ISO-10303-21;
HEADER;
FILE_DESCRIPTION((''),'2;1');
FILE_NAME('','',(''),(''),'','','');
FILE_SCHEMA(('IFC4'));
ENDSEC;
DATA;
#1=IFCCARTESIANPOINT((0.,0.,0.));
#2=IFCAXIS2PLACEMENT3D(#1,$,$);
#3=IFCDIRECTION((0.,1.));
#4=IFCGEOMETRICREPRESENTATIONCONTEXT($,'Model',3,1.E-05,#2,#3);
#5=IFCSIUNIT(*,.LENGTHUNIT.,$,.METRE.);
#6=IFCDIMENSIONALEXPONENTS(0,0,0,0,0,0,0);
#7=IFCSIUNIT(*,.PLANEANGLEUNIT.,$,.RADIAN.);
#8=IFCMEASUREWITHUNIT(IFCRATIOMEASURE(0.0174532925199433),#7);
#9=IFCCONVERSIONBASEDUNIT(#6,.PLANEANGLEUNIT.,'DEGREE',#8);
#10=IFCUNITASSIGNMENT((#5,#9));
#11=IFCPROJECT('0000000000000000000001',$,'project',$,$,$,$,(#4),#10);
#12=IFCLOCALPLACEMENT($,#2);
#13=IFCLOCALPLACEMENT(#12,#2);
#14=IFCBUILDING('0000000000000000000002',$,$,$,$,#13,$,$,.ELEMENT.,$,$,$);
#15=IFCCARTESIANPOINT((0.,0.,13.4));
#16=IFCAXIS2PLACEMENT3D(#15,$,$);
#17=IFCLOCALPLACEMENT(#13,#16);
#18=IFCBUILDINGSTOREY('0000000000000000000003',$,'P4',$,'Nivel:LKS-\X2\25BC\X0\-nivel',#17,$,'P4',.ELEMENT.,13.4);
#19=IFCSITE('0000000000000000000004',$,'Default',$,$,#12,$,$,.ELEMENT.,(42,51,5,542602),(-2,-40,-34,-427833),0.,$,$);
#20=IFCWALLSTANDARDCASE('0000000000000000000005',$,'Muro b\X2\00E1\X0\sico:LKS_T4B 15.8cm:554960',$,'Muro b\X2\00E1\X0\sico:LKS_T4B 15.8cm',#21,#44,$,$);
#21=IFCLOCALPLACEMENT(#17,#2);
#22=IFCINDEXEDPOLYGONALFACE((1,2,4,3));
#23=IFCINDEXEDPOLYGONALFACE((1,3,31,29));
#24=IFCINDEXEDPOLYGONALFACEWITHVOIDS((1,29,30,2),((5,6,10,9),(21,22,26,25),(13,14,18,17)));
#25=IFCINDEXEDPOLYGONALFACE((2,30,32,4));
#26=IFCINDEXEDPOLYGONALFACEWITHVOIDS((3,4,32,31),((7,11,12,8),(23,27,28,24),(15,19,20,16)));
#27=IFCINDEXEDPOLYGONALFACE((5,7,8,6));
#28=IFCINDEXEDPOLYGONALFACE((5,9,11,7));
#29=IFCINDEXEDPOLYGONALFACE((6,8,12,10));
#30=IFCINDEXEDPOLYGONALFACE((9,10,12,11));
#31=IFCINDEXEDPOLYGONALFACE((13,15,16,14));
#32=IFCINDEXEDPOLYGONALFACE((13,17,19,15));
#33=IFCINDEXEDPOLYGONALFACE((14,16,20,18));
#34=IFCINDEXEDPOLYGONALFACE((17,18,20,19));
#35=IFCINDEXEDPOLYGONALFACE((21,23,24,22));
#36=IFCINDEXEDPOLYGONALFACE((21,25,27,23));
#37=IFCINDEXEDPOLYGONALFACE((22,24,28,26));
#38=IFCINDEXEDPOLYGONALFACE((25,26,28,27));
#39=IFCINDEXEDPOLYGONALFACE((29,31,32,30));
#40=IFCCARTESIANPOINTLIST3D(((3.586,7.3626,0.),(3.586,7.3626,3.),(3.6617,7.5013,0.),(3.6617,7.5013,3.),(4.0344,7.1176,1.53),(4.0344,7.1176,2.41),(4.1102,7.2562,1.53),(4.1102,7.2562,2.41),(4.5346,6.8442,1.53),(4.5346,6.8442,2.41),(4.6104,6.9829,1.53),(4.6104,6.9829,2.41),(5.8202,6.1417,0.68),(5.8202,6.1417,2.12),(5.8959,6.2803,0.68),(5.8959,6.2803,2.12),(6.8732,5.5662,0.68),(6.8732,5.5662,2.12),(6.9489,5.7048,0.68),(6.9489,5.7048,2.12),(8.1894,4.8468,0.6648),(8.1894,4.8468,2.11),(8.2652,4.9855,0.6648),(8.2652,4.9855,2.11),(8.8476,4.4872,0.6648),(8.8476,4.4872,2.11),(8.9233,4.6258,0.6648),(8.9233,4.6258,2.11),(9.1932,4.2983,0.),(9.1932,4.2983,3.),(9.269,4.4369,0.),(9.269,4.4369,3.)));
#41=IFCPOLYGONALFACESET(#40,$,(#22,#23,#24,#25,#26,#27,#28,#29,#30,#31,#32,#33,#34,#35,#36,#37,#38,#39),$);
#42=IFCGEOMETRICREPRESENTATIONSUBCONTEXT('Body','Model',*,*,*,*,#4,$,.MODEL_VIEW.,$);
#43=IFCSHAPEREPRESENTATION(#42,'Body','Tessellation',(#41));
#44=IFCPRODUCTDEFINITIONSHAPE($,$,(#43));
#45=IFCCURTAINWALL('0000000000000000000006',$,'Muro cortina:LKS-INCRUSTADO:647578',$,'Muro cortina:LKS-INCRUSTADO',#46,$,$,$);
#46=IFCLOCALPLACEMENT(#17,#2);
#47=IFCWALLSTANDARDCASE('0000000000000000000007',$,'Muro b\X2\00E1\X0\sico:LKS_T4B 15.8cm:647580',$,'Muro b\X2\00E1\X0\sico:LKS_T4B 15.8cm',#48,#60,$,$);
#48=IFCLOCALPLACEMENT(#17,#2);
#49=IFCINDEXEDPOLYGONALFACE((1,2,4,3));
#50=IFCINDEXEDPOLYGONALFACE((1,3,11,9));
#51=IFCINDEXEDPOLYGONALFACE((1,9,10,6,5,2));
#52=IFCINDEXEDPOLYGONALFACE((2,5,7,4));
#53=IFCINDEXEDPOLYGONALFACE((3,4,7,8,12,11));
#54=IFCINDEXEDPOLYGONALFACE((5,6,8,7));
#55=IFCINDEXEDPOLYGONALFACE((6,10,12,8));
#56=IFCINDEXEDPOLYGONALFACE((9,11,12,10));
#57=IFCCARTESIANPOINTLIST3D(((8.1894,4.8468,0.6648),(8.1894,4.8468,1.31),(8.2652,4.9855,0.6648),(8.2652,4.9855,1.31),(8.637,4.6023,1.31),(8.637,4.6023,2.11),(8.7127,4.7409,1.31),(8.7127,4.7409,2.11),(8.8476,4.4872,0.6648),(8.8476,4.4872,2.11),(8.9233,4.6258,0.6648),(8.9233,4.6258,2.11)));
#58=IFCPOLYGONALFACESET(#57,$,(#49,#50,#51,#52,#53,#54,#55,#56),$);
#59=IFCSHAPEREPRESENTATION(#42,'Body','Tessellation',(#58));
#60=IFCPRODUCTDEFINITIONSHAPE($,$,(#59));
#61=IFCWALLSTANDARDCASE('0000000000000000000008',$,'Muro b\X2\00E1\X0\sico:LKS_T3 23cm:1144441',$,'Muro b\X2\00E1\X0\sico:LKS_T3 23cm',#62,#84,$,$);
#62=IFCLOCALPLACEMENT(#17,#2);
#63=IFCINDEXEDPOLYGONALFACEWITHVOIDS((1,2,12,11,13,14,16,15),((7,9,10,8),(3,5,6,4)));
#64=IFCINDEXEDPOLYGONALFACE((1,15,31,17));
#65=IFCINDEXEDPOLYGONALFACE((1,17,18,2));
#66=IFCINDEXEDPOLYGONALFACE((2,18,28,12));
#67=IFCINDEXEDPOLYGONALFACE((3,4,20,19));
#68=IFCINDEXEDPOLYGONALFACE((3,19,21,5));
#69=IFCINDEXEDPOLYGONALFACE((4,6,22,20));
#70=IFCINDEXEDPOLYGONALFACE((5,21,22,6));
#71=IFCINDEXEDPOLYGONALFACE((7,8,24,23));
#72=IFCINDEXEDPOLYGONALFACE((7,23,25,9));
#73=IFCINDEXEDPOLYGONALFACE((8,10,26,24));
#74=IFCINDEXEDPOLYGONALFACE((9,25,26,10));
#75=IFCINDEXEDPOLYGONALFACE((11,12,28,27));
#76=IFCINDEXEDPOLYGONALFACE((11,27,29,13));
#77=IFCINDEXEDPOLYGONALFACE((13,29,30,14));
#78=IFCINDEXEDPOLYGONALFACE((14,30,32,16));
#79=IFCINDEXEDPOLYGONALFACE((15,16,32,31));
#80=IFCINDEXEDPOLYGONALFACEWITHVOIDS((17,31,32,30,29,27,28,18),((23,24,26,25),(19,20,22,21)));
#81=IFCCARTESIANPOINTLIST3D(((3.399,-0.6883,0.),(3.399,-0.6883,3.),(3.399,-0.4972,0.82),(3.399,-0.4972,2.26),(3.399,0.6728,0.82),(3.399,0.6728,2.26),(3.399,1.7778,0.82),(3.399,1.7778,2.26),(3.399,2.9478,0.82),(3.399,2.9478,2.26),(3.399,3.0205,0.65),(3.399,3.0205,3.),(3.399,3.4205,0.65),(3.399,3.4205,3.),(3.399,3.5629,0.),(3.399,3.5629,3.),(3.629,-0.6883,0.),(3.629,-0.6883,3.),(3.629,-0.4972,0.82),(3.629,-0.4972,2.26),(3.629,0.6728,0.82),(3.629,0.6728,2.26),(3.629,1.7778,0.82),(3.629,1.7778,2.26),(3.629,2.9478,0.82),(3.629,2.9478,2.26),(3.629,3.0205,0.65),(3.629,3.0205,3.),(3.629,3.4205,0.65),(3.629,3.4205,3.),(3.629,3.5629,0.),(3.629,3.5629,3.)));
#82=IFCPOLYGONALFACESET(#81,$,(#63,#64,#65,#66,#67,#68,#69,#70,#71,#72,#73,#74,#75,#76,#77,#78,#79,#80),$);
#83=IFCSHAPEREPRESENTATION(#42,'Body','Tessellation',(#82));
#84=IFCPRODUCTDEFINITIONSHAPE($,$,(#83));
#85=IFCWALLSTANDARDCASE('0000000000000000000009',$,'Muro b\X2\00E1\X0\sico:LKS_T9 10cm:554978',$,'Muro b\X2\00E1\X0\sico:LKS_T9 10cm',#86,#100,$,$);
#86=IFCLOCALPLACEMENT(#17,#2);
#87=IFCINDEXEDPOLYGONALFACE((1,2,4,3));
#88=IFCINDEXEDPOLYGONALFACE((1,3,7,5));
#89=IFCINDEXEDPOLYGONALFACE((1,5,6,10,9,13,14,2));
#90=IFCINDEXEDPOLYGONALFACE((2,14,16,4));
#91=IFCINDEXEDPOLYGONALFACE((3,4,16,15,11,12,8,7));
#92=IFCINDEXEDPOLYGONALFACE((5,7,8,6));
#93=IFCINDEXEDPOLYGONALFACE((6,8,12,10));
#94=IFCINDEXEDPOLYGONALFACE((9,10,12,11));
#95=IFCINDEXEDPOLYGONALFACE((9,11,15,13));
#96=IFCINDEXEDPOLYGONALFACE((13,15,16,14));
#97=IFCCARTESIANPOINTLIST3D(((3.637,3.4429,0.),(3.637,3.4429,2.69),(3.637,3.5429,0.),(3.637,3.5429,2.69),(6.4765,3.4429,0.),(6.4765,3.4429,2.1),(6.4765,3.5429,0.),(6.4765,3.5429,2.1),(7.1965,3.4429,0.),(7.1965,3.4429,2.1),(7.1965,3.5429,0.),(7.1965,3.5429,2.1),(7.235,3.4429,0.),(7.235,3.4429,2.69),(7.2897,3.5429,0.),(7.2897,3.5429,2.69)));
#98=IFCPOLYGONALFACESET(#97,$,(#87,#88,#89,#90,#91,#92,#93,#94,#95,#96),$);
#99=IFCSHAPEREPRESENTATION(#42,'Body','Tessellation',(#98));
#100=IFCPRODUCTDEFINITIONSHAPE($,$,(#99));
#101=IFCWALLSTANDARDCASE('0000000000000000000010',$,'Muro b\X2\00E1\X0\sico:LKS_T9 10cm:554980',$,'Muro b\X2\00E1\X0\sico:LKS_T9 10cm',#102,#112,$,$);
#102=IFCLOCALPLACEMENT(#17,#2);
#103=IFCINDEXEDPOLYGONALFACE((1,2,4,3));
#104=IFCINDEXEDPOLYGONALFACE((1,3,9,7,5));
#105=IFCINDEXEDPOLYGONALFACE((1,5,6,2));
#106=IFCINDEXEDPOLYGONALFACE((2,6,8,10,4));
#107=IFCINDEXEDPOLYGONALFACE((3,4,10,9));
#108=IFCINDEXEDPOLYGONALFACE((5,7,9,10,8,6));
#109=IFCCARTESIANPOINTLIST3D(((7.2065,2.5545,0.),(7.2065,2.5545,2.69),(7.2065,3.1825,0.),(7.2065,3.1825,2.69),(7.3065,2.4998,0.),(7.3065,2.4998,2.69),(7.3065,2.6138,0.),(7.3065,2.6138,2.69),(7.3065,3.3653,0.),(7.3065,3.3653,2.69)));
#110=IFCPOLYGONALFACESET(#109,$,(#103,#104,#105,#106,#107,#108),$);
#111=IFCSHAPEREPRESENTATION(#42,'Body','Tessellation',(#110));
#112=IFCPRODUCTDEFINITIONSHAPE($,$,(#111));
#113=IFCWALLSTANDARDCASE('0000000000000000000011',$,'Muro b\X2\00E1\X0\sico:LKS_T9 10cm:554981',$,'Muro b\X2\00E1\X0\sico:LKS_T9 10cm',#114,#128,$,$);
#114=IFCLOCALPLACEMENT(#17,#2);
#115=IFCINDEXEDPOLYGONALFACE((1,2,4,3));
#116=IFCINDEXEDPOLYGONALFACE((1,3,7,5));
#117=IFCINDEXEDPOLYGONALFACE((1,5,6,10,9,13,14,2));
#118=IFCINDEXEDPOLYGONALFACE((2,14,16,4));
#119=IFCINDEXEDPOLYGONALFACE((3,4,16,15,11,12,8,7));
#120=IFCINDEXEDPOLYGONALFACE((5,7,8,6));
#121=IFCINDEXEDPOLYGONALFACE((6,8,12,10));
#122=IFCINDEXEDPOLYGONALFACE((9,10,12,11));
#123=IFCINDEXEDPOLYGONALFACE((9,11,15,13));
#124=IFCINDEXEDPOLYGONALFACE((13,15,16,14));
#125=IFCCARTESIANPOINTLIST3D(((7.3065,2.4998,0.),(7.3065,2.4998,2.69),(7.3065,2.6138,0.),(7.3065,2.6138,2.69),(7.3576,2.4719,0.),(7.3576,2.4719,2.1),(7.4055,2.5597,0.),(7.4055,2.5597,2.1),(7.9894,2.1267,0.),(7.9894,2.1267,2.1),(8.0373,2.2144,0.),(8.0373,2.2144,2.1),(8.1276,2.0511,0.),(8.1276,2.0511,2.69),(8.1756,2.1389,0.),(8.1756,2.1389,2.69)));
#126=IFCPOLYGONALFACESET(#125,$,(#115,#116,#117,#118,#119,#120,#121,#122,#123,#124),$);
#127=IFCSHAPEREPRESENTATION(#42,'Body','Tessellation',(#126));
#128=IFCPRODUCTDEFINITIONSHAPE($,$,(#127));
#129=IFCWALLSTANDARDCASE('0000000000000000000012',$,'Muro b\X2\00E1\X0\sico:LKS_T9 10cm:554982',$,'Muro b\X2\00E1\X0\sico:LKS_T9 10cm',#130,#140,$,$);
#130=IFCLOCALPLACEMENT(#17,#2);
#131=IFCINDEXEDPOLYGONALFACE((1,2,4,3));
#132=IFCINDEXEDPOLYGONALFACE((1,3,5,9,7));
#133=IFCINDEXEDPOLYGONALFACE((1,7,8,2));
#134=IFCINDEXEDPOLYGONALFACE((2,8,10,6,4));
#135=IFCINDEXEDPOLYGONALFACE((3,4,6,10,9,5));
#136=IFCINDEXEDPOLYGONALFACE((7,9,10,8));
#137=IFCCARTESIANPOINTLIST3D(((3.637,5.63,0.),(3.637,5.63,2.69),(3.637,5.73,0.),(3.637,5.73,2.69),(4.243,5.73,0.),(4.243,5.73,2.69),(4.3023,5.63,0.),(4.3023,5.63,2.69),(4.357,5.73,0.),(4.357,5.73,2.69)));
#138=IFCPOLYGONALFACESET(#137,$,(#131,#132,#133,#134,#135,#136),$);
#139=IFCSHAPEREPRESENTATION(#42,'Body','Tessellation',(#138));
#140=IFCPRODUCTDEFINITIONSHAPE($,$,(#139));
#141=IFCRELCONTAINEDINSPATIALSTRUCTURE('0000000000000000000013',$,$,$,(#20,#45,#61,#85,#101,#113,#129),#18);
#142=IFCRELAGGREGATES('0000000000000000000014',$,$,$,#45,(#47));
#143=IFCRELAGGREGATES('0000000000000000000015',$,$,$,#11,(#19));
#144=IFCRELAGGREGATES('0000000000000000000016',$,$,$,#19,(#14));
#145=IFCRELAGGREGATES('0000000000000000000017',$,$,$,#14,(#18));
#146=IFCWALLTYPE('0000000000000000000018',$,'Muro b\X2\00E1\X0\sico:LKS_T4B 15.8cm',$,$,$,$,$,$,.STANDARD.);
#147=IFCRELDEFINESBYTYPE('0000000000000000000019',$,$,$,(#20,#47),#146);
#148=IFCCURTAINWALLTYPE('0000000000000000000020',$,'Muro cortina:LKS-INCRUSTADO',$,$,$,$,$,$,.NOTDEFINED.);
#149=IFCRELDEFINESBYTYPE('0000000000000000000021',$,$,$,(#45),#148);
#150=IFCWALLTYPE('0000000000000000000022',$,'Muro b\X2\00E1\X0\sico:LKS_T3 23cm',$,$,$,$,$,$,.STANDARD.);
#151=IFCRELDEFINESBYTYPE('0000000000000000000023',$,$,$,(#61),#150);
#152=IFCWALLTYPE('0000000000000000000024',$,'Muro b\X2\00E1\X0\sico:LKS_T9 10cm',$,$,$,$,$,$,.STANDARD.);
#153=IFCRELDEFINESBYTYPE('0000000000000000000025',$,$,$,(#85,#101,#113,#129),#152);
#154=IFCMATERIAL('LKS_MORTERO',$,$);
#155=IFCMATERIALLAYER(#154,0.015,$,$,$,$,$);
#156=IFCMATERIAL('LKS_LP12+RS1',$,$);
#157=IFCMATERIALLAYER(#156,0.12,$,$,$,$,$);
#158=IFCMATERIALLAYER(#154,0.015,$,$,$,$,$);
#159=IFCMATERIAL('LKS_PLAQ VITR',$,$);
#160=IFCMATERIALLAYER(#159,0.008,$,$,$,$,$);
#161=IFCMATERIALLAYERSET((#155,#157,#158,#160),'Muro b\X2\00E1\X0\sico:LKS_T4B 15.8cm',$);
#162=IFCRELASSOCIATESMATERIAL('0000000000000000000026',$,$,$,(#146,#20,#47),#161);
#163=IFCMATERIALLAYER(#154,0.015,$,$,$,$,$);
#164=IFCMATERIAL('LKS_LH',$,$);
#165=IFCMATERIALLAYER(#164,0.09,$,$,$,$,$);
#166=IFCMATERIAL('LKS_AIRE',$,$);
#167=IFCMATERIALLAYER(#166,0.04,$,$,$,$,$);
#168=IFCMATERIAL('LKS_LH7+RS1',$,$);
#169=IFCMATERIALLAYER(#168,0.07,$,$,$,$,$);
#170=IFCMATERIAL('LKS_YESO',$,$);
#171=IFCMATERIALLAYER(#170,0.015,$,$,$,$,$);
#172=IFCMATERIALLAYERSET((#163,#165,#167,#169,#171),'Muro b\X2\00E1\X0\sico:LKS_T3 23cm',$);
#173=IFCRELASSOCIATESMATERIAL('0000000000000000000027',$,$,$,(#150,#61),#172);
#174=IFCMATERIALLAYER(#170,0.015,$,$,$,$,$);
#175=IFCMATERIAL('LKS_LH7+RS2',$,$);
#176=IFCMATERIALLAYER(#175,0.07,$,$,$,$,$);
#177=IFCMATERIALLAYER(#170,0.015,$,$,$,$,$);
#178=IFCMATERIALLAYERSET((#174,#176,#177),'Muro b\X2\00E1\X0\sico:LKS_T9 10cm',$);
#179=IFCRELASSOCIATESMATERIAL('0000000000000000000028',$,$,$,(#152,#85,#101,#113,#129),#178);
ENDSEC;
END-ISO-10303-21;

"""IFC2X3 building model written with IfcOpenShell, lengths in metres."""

from ifc_helpers import new_model, entity, si_unit, converted_unit, direction, frame, frame_2d, origin, place, context, subcontext, project, spatial, polyline, rectangle, outline, extrude, clip, bounded_halfspace, material, layer, layer_set, layer_usage, type_object, element, aggregate, save


model = new_model("IFC2X3")

# Units and contexts
model_context = context("Model", 3, precision=1e-05, world=origin(), true_north=direction((0.0, 1.0)))
body_context = subcontext(model_context, "Body", "Model", "MODEL_VIEW")
ifc_project = project(units=[si_unit("LENGTHUNIT", "METRE"), converted_unit("PLANEANGLEUNIT", "DEGREE", entity("IfcRatioMeasure", 0.0174532925199433), si_unit("PLANEANGLEUNIT", "RADIAN"), dimensions=[0, 0, 0, 0, 0, 0, 0])], contexts=[model_context])

# Site, building, storey
site_placement = place(None, origin())
site = spatial("IfcSite", under=ifc_project, at=site_placement, Name="Default", CompositionType="ELEMENT", RefLatitude=(42, 51, 5, 542602), RefLongitude=(-2, -40, -34, -427833), RefElevation=0.0)
building_placement = place(site_placement, origin())
building = spatial("IfcBuilding", under=site, at=building_placement, CompositionType="ELEMENT")
storey_placement = place(building_placement, frame((0.0, 0.0, 13.4)))
storey = spatial("IfcBuildingStorey", under=building, at=storey_placement, Name="P4", ObjectType="Nivel:LKS-▼-nivel", LongName="P4", CompositionType="ELEMENT", Elevation=13.4)

# Shared definitions
ifc_material_1 = material(Name="LKS_MORTERO")
ifc_layer_1 = layer(ifc_material_1, 0.015)
ifc_material_2 = material(Name="LKS_LP12+RS1")
ifc_layer_2 = layer(ifc_material_2, 0.12)
ifc_layer_3 = layer(ifc_material_1, 0.015)
ifc_material_3 = material(Name="LKS_PLAQ VITR")
ifc_layer_4 = layer(ifc_material_3, 0.008)
ifc_layer_set_1 = layer_set([ifc_layer_1, ifc_layer_2, ifc_layer_3, ifc_layer_4], Name="Muro básico:LKS_T4B 15.8cm")
wall_type_1 = type_object("IfcWallType", Name="Muro básico:LKS_T4B 15.8cm", PredefinedType="STANDARD", material=ifc_layer_set_1)

# Wall, openings
ifc_layer_usage_1 = layer_usage(ifc_layer_set_1, "AXIS2", "POSITIVE", -0.079)
wall_1_placement = place(storey_placement, frame((9.2311, 4.3676, 0.0), z_axis=(0.0, 0.0, 1.0), x_axis=(-0.877509, 0.479561, 0.0)))
wall_1 = element("IfcWallStandardCase", 1, at=wall_1_placement, inside=storey, type_object=wall_type_1, material=ifc_layer_usage_1, Name="Muro básico:LKS_T4B 15.8cm:554960", ObjectType="Muro básico:LKS_T4B 15.8cm", context=body_context, shape_type="Clipping", body=[
    clip(clip(extrude(rectangle(XDim=6.39, YDim=0.158, at=frame_2d((3.195, 0.0), x_axis=(-1.0, 0.0))), origin(), (0.0, 0.0, 1.0), 3.0), bounded_halfspace(frame((6.39, -0.079, 3.0), z_axis=(-1.0, 0.0, 0.0), x_axis=(0.0, 0.0, -1.0)), True, frame((6.39, -0.079, 3.0), z_axis=(-1.0, 0.0, 0.0), x_axis=(0.0, 0.0, -1.0)), polyline([(0.0, 0.0), (0.0, -0.0455), (0.0, -0.158), (3.0, -0.158), (3.0, 0.0), (0.0, 0.0)]))), bounded_halfspace(frame((0.0, -0.079, 0.0), z_axis=(1.0, 0.0, 0.0), x_axis=(0.0, 0.0, -1.0)), True, frame((0.0, -0.079, 0.0), z_axis=(1.0, 0.0, 0.0), x_axis=(0.0, 0.0, -1.0)), polyline([(0.0, 0.0), (0.0, 0.158), (-3.0, 0.158), (-3.0, 0.0488), (-3.0, 0.0), (0.0, 0.0)]))),
])
opening_1_placement = place(wall_1_placement, origin())
element("IfcOpeningElement", 2, at=opening_1_placement, cuts=wall_1, ObjectType="Opening", context=body_context, shape_type="SweptSolid", body=[
    extrude(rectangle(XDim=1.4452, YDim=0.75, at=frame_2d((0.0, 0.0), x_axis=(0.0, 1.0))), frame((0.7689, -0.2314, 1.3874), z_axis=(0.0, 1.0, 0.0), x_axis=(-1.0, 0.0, 0.0)), (0.0, 0.0, 1.0), 0.4628),
])
opening_2_placement = place(wall_1_placement, frame((3.8439, 0.079, 0.68)))
element("IfcOpeningElement", 3, at=opening_2_placement, cuts=wall_1, ObjectType="Opening", context=body_context, shape_type="SweptSolid", body=[
    extrude(rectangle(XDim=1.44, YDim=1.2, at=frame_2d((0.72, 0.6), x_axis=(1.0, 0.0))), frame((0.0, 0.0, 0.0), z_axis=(0.0, -1.0, 0.0), x_axis=(0.0, 0.0, 1.0)), (0.0, 0.0, 1.0), 0.158),
])
opening_3_placement = place(wall_1_placement, frame((5.8789, 0.079, 1.53)))
element("IfcOpeningElement", 4, at=opening_3_placement, cuts=wall_1, ObjectType="Opening", context=body_context, shape_type="SweptSolid", body=[
    extrude(rectangle(XDim=0.88, YDim=0.57, at=frame_2d((0.44, 0.285), x_axis=(1.0, 0.0))), frame((0.0, 0.0, 0.0), z_axis=(0.0, -1.0, 0.0), x_axis=(0.0, 0.0, 1.0)), (0.0, 0.0, 1.0), 0.158),
])

# Curtain wall, wall, opening
curtain_wall_type = type_object("IfcCurtainWallType", Name="Muro cortina:LKS-INCRUSTADO", PredefinedType="NOTDEFINED")
curtain_wall_placement = place(storey_placement, frame((0.0, 0.0, -13.4)))
curtain_wall = element("IfcCurtainWall", 5, at=curtain_wall_placement, inside=storey, type_object=curtain_wall_type, Name="Muro cortina:LKS-INCRUSTADO:647578", ObjectType="Muro cortina:LKS-INCRUSTADO")
ifc_layer_usage_2 = layer_usage(ifc_layer_set_1, "AXIS2", "NEGATIVE", 0.079)
wall_2_placement = place(storey_placement, frame((8.2273, 4.9162, 0.6648), z_axis=(0.0, 0.0, 1.0), x_axis=(0.877509, -0.479561, 0.0)))
wall_2 = element("IfcWallStandardCase", 6, at=wall_2_placement, type_object=wall_type_1, material=ifc_layer_usage_2, Name="Muro básico:LKS_T4B 15.8cm:647580", ObjectType="Muro básico:LKS_T4B 15.8cm", context=body_context, shape_type="SweptSolid", body=[
    extrude(rectangle(XDim=0.75, YDim=0.158, at=frame_2d((0.375, 0.0), x_axis=(-1.0, 0.0))), origin(), (0.0, 0.0, 1.0), 1.4452),
])
opening_4_placement = place(wall_2_placement, frame((0.0, -0.079, 0.6452)))
element("IfcOpeningElement", 7, at=opening_4_placement, cuts=wall_2, ObjectType="Opening", context=body_context, shape_type="SweptSolid", body=[
    extrude(rectangle(XDim=0.81, YDim=0.51, at=frame_2d((0.405, 0.255), x_axis=(1.0, 0.0))), frame((0.0, 0.0, 0.0), z_axis=(0.0, 1.0, 0.0), x_axis=(0.0, 0.0, 1.0)), (0.0, 0.0, 1.0), 0.158),
])
aggregate(curtain_wall, [wall_2])

# Wall, openings
ifc_layer_5 = layer(ifc_material_1, 0.015)
ifc_material_4 = material(Name="LKS_LH")
ifc_layer_6 = layer(ifc_material_4, 0.09)
ifc_material_5 = material(Name="LKS_AIRE")
ifc_layer_7 = layer(ifc_material_5, 0.04)
ifc_material_6 = material(Name="LKS_LH7+RS1")
ifc_layer_8 = layer(ifc_material_6, 0.07)
ifc_material_7 = material(Name="LKS_YESO")
ifc_layer_9 = layer(ifc_material_7, 0.015)
ifc_layer_set_2 = layer_set([ifc_layer_5, ifc_layer_6, ifc_layer_7, ifc_layer_8, ifc_layer_9], Name="Muro básico:LKS_T3 23cm")
ifc_layer_usage_3 = layer_usage(ifc_layer_set_2, "AXIS2", "NEGATIVE", 0.115)
wall_type_2 = type_object("IfcWallType", Name="Muro básico:LKS_T3 23cm", PredefinedType="STANDARD", material=ifc_layer_set_2)
wall_3_placement = place(storey_placement, frame((3.514, 3.5629, 0.0), z_axis=(0.0, 0.0, 1.0), x_axis=(0.0, -1.0, 0.0)))
wall_3 = element("IfcWallStandardCase", 8, at=wall_3_placement, inside=storey, type_object=wall_type_2, material=ifc_layer_usage_3, Name="Muro básico:LKS_T3 23cm:1144441", ObjectType="Muro básico:LKS_T3 23cm", context=body_context, shape_type="Clipping", body=[
    clip(extrude(rectangle(XDim=4.2511, YDim=0.23, at=frame_2d((2.1256, 0.0), x_axis=(-1.0, 0.0))), origin(), (0.0, 0.0, 1.0), 3.0), bounded_halfspace(frame((0.5424, -0.115, 0.65), z_axis=(0.0, 0.0, -1.0), x_axis=(0.0, -1.0, 0.0)), True, frame((0.5424, -0.115, 0.65), z_axis=(0.0, 0.0, -1.0), x_axis=(0.0, -1.0, 0.0)), polyline([(0.0, 0.0), (0.0, 0.4), (-0.23, 0.4), (-0.23, 0.0), (0.0, 0.0)]))),
])
opening_5_placement = place(wall_3_placement, frame((4.0601, 0.115, 0.82)))
element("IfcOpeningElement", 9, at=opening_5_placement, cuts=wall_3, ObjectType="Opening", context=body_context, shape_type="SweptSolid", body=[
    extrude(rectangle(XDim=1.44, YDim=1.17, at=frame_2d((0.72, 0.585), x_axis=(1.0, 0.0))), frame((0.0, 0.0, 0.0), z_axis=(0.0, -1.0, 0.0), x_axis=(0.0, 0.0, 1.0)), (0.0, 0.0, 1.0), 0.23),
])
opening_6_placement = place(wall_3_placement, frame((1.7851, 0.115, 0.82)))
element("IfcOpeningElement", 10, at=opening_6_placement, cuts=wall_3, ObjectType="Opening", context=body_context, shape_type="SweptSolid", body=[
    extrude(rectangle(XDim=1.44, YDim=1.17, at=frame_2d((0.72, 0.585), x_axis=(1.0, 0.0))), frame((0.0, 0.0, 0.0), z_axis=(0.0, -1.0, 0.0), x_axis=(0.0, 0.0, 1.0)), (0.0, 0.0, 1.0), 0.23),
])

# Wall, opening
ifc_layer_10 = layer(ifc_material_7, 0.015)
ifc_material_8 = material(Name="LKS_LH7+RS2")
ifc_layer_11 = layer(ifc_material_8, 0.07)
ifc_layer_12 = layer(ifc_material_7, 0.015)
ifc_layer_set_3 = layer_set([ifc_layer_10, ifc_layer_11, ifc_layer_12], Name="Muro básico:LKS_T9 10cm")
ifc_layer_usage_4 = layer_usage(ifc_layer_set_3, "AXIS2", "NEGATIVE", 0.05)
wall_type_3 = type_object("IfcWallType", Name="Muro básico:LKS_T9 10cm", PredefinedType="STANDARD", material=ifc_layer_set_3)
wall_4_placement = place(storey_placement, frame((7.2897, 3.4929, 0.0), z_axis=(0.0, 0.0, 1.0), x_axis=(-1.0, 0.0, 0.0)))
wall_4 = element("IfcWallStandardCase", 11, at=wall_4_placement, inside=storey, type_object=wall_type_3, material=ifc_layer_usage_4, Name="Muro básico:LKS_T9 10cm:554978", ObjectType="Muro básico:LKS_T9 10cm", context=body_context, shape_type="SweptSolid", body=[
    extrude(outline(polyline([(0.0, -0.05), (3.6528, -0.05), (3.6528, 0.05), (1.0132, 0.05), (0.9132, 0.05), (0.0547, 0.05), (0.0, -0.05)])), origin(), (0.0, 0.0, 1.0), 2.69),
])
opening_7_placement = place(wall_4_placement, frame((0.8132, 0.05, 0.0)))
element("IfcOpeningElement", 12, at=opening_7_placement, cuts=wall_4, ObjectType="Opening", context=body_context, shape_type="SweptSolid", body=[
    extrude(rectangle(XDim=2.1, YDim=0.72, at=frame_2d((1.05, 0.36), x_axis=(1.0, 0.0))), frame((0.0, 0.0, 0.0), z_axis=(0.0, -1.0, 0.0), x_axis=(0.0, 0.0, 1.0)), (0.0, 0.0, 1.0), 0.1),
])

# Wall
ifc_layer_usage_5 = layer_usage(ifc_layer_set_3, "AXIS2", "POSITIVE", -0.05)
wall_5_placement = place(storey_placement, frame((7.2565, 3.3653, 0.0), z_axis=(0.0, 0.0, 1.0), x_axis=(0.0, -1.0, 0.0)))
element("IfcWallStandardCase", 13, at=wall_5_placement, inside=storey, type_object=wall_type_3, material=ifc_layer_usage_5, Name="Muro básico:LKS_T9 10cm:554980", ObjectType="Muro básico:LKS_T9 10cm", context=body_context, shape_type="SweptSolid", body=[
    extrude(outline(polyline([(0.8108, -0.05), (0.8655, 0.05), (0.7515, 0.05), (0.0, 0.05), (0.1828, -0.05), (0.8108, -0.05)])), origin(), (0.0, 0.0, 1.0), 2.69),
])

# Wall, opening
ifc_layer_usage_6 = layer_usage(ifc_layer_set_3, "AXIS2", "NEGATIVE", 0.05)
wall_6_placement = place(storey_placement, frame((7.2826, 2.5699, 0.0), z_axis=(0.0, 0.0, 1.0), x_axis=(0.877509, -0.479561, 0.0)))
wall_6 = element("IfcWallStandardCase", 14, at=wall_6_placement, inside=storey, type_object=wall_type_3, material=ifc_layer_usage_6, Name="Muro básico:LKS_T9 10cm:554981", ObjectType="Muro básico:LKS_T9 10cm", context=body_context, shape_type="SweptSolid", body=[
    extrude(outline(polyline([(0.0547, -0.05), (0.9903, -0.05), (0.9903, 0.05), (0.0, 0.05), (0.0547, -0.05)])), origin(), (0.0, 0.0, 1.0), 2.69),
])
opening_8_placement = place(wall_6_placement, frame((0.1128, -0.05, 0.0)))
element("IfcOpeningElement", 15, at=opening_8_placement, cuts=wall_6, ObjectType="Opening", context=body_context, shape_type="SweptSolid", body=[
    extrude(rectangle(XDim=2.1, YDim=0.72, at=frame_2d((1.05, 0.36), x_axis=(1.0, 0.0))), frame((0.0, 0.0, 0.0), z_axis=(0.0, 1.0, 0.0), x_axis=(0.0, 0.0, 1.0)), (0.0, 0.0, 1.0), 0.1),
])

# Wall
ifc_layer_usage_7 = layer_usage(ifc_layer_set_3, "AXIS2", "NEGATIVE", 0.05)
wall_7_placement = place(storey_placement, frame((3.637, 5.68, 0.0)))
element("IfcWallStandardCase", 16, at=wall_7_placement, inside=storey, type_object=wall_type_3, material=ifc_layer_usage_7, Name="Muro básico:LKS_T9 10cm:554982", ObjectType="Muro básico:LKS_T9 10cm", context=body_context, shape_type="SweptSolid", body=[
    extrude(outline(polyline([(0.6654, -0.05), (0.7201, 0.05), (0.6061, 0.05), (0.0, 0.05), (0.0, -0.05), (0.6654, -0.05)])), origin(), (0.0, 0.0, 1.0), 2.69),
])

save(model, "model.ifc")
